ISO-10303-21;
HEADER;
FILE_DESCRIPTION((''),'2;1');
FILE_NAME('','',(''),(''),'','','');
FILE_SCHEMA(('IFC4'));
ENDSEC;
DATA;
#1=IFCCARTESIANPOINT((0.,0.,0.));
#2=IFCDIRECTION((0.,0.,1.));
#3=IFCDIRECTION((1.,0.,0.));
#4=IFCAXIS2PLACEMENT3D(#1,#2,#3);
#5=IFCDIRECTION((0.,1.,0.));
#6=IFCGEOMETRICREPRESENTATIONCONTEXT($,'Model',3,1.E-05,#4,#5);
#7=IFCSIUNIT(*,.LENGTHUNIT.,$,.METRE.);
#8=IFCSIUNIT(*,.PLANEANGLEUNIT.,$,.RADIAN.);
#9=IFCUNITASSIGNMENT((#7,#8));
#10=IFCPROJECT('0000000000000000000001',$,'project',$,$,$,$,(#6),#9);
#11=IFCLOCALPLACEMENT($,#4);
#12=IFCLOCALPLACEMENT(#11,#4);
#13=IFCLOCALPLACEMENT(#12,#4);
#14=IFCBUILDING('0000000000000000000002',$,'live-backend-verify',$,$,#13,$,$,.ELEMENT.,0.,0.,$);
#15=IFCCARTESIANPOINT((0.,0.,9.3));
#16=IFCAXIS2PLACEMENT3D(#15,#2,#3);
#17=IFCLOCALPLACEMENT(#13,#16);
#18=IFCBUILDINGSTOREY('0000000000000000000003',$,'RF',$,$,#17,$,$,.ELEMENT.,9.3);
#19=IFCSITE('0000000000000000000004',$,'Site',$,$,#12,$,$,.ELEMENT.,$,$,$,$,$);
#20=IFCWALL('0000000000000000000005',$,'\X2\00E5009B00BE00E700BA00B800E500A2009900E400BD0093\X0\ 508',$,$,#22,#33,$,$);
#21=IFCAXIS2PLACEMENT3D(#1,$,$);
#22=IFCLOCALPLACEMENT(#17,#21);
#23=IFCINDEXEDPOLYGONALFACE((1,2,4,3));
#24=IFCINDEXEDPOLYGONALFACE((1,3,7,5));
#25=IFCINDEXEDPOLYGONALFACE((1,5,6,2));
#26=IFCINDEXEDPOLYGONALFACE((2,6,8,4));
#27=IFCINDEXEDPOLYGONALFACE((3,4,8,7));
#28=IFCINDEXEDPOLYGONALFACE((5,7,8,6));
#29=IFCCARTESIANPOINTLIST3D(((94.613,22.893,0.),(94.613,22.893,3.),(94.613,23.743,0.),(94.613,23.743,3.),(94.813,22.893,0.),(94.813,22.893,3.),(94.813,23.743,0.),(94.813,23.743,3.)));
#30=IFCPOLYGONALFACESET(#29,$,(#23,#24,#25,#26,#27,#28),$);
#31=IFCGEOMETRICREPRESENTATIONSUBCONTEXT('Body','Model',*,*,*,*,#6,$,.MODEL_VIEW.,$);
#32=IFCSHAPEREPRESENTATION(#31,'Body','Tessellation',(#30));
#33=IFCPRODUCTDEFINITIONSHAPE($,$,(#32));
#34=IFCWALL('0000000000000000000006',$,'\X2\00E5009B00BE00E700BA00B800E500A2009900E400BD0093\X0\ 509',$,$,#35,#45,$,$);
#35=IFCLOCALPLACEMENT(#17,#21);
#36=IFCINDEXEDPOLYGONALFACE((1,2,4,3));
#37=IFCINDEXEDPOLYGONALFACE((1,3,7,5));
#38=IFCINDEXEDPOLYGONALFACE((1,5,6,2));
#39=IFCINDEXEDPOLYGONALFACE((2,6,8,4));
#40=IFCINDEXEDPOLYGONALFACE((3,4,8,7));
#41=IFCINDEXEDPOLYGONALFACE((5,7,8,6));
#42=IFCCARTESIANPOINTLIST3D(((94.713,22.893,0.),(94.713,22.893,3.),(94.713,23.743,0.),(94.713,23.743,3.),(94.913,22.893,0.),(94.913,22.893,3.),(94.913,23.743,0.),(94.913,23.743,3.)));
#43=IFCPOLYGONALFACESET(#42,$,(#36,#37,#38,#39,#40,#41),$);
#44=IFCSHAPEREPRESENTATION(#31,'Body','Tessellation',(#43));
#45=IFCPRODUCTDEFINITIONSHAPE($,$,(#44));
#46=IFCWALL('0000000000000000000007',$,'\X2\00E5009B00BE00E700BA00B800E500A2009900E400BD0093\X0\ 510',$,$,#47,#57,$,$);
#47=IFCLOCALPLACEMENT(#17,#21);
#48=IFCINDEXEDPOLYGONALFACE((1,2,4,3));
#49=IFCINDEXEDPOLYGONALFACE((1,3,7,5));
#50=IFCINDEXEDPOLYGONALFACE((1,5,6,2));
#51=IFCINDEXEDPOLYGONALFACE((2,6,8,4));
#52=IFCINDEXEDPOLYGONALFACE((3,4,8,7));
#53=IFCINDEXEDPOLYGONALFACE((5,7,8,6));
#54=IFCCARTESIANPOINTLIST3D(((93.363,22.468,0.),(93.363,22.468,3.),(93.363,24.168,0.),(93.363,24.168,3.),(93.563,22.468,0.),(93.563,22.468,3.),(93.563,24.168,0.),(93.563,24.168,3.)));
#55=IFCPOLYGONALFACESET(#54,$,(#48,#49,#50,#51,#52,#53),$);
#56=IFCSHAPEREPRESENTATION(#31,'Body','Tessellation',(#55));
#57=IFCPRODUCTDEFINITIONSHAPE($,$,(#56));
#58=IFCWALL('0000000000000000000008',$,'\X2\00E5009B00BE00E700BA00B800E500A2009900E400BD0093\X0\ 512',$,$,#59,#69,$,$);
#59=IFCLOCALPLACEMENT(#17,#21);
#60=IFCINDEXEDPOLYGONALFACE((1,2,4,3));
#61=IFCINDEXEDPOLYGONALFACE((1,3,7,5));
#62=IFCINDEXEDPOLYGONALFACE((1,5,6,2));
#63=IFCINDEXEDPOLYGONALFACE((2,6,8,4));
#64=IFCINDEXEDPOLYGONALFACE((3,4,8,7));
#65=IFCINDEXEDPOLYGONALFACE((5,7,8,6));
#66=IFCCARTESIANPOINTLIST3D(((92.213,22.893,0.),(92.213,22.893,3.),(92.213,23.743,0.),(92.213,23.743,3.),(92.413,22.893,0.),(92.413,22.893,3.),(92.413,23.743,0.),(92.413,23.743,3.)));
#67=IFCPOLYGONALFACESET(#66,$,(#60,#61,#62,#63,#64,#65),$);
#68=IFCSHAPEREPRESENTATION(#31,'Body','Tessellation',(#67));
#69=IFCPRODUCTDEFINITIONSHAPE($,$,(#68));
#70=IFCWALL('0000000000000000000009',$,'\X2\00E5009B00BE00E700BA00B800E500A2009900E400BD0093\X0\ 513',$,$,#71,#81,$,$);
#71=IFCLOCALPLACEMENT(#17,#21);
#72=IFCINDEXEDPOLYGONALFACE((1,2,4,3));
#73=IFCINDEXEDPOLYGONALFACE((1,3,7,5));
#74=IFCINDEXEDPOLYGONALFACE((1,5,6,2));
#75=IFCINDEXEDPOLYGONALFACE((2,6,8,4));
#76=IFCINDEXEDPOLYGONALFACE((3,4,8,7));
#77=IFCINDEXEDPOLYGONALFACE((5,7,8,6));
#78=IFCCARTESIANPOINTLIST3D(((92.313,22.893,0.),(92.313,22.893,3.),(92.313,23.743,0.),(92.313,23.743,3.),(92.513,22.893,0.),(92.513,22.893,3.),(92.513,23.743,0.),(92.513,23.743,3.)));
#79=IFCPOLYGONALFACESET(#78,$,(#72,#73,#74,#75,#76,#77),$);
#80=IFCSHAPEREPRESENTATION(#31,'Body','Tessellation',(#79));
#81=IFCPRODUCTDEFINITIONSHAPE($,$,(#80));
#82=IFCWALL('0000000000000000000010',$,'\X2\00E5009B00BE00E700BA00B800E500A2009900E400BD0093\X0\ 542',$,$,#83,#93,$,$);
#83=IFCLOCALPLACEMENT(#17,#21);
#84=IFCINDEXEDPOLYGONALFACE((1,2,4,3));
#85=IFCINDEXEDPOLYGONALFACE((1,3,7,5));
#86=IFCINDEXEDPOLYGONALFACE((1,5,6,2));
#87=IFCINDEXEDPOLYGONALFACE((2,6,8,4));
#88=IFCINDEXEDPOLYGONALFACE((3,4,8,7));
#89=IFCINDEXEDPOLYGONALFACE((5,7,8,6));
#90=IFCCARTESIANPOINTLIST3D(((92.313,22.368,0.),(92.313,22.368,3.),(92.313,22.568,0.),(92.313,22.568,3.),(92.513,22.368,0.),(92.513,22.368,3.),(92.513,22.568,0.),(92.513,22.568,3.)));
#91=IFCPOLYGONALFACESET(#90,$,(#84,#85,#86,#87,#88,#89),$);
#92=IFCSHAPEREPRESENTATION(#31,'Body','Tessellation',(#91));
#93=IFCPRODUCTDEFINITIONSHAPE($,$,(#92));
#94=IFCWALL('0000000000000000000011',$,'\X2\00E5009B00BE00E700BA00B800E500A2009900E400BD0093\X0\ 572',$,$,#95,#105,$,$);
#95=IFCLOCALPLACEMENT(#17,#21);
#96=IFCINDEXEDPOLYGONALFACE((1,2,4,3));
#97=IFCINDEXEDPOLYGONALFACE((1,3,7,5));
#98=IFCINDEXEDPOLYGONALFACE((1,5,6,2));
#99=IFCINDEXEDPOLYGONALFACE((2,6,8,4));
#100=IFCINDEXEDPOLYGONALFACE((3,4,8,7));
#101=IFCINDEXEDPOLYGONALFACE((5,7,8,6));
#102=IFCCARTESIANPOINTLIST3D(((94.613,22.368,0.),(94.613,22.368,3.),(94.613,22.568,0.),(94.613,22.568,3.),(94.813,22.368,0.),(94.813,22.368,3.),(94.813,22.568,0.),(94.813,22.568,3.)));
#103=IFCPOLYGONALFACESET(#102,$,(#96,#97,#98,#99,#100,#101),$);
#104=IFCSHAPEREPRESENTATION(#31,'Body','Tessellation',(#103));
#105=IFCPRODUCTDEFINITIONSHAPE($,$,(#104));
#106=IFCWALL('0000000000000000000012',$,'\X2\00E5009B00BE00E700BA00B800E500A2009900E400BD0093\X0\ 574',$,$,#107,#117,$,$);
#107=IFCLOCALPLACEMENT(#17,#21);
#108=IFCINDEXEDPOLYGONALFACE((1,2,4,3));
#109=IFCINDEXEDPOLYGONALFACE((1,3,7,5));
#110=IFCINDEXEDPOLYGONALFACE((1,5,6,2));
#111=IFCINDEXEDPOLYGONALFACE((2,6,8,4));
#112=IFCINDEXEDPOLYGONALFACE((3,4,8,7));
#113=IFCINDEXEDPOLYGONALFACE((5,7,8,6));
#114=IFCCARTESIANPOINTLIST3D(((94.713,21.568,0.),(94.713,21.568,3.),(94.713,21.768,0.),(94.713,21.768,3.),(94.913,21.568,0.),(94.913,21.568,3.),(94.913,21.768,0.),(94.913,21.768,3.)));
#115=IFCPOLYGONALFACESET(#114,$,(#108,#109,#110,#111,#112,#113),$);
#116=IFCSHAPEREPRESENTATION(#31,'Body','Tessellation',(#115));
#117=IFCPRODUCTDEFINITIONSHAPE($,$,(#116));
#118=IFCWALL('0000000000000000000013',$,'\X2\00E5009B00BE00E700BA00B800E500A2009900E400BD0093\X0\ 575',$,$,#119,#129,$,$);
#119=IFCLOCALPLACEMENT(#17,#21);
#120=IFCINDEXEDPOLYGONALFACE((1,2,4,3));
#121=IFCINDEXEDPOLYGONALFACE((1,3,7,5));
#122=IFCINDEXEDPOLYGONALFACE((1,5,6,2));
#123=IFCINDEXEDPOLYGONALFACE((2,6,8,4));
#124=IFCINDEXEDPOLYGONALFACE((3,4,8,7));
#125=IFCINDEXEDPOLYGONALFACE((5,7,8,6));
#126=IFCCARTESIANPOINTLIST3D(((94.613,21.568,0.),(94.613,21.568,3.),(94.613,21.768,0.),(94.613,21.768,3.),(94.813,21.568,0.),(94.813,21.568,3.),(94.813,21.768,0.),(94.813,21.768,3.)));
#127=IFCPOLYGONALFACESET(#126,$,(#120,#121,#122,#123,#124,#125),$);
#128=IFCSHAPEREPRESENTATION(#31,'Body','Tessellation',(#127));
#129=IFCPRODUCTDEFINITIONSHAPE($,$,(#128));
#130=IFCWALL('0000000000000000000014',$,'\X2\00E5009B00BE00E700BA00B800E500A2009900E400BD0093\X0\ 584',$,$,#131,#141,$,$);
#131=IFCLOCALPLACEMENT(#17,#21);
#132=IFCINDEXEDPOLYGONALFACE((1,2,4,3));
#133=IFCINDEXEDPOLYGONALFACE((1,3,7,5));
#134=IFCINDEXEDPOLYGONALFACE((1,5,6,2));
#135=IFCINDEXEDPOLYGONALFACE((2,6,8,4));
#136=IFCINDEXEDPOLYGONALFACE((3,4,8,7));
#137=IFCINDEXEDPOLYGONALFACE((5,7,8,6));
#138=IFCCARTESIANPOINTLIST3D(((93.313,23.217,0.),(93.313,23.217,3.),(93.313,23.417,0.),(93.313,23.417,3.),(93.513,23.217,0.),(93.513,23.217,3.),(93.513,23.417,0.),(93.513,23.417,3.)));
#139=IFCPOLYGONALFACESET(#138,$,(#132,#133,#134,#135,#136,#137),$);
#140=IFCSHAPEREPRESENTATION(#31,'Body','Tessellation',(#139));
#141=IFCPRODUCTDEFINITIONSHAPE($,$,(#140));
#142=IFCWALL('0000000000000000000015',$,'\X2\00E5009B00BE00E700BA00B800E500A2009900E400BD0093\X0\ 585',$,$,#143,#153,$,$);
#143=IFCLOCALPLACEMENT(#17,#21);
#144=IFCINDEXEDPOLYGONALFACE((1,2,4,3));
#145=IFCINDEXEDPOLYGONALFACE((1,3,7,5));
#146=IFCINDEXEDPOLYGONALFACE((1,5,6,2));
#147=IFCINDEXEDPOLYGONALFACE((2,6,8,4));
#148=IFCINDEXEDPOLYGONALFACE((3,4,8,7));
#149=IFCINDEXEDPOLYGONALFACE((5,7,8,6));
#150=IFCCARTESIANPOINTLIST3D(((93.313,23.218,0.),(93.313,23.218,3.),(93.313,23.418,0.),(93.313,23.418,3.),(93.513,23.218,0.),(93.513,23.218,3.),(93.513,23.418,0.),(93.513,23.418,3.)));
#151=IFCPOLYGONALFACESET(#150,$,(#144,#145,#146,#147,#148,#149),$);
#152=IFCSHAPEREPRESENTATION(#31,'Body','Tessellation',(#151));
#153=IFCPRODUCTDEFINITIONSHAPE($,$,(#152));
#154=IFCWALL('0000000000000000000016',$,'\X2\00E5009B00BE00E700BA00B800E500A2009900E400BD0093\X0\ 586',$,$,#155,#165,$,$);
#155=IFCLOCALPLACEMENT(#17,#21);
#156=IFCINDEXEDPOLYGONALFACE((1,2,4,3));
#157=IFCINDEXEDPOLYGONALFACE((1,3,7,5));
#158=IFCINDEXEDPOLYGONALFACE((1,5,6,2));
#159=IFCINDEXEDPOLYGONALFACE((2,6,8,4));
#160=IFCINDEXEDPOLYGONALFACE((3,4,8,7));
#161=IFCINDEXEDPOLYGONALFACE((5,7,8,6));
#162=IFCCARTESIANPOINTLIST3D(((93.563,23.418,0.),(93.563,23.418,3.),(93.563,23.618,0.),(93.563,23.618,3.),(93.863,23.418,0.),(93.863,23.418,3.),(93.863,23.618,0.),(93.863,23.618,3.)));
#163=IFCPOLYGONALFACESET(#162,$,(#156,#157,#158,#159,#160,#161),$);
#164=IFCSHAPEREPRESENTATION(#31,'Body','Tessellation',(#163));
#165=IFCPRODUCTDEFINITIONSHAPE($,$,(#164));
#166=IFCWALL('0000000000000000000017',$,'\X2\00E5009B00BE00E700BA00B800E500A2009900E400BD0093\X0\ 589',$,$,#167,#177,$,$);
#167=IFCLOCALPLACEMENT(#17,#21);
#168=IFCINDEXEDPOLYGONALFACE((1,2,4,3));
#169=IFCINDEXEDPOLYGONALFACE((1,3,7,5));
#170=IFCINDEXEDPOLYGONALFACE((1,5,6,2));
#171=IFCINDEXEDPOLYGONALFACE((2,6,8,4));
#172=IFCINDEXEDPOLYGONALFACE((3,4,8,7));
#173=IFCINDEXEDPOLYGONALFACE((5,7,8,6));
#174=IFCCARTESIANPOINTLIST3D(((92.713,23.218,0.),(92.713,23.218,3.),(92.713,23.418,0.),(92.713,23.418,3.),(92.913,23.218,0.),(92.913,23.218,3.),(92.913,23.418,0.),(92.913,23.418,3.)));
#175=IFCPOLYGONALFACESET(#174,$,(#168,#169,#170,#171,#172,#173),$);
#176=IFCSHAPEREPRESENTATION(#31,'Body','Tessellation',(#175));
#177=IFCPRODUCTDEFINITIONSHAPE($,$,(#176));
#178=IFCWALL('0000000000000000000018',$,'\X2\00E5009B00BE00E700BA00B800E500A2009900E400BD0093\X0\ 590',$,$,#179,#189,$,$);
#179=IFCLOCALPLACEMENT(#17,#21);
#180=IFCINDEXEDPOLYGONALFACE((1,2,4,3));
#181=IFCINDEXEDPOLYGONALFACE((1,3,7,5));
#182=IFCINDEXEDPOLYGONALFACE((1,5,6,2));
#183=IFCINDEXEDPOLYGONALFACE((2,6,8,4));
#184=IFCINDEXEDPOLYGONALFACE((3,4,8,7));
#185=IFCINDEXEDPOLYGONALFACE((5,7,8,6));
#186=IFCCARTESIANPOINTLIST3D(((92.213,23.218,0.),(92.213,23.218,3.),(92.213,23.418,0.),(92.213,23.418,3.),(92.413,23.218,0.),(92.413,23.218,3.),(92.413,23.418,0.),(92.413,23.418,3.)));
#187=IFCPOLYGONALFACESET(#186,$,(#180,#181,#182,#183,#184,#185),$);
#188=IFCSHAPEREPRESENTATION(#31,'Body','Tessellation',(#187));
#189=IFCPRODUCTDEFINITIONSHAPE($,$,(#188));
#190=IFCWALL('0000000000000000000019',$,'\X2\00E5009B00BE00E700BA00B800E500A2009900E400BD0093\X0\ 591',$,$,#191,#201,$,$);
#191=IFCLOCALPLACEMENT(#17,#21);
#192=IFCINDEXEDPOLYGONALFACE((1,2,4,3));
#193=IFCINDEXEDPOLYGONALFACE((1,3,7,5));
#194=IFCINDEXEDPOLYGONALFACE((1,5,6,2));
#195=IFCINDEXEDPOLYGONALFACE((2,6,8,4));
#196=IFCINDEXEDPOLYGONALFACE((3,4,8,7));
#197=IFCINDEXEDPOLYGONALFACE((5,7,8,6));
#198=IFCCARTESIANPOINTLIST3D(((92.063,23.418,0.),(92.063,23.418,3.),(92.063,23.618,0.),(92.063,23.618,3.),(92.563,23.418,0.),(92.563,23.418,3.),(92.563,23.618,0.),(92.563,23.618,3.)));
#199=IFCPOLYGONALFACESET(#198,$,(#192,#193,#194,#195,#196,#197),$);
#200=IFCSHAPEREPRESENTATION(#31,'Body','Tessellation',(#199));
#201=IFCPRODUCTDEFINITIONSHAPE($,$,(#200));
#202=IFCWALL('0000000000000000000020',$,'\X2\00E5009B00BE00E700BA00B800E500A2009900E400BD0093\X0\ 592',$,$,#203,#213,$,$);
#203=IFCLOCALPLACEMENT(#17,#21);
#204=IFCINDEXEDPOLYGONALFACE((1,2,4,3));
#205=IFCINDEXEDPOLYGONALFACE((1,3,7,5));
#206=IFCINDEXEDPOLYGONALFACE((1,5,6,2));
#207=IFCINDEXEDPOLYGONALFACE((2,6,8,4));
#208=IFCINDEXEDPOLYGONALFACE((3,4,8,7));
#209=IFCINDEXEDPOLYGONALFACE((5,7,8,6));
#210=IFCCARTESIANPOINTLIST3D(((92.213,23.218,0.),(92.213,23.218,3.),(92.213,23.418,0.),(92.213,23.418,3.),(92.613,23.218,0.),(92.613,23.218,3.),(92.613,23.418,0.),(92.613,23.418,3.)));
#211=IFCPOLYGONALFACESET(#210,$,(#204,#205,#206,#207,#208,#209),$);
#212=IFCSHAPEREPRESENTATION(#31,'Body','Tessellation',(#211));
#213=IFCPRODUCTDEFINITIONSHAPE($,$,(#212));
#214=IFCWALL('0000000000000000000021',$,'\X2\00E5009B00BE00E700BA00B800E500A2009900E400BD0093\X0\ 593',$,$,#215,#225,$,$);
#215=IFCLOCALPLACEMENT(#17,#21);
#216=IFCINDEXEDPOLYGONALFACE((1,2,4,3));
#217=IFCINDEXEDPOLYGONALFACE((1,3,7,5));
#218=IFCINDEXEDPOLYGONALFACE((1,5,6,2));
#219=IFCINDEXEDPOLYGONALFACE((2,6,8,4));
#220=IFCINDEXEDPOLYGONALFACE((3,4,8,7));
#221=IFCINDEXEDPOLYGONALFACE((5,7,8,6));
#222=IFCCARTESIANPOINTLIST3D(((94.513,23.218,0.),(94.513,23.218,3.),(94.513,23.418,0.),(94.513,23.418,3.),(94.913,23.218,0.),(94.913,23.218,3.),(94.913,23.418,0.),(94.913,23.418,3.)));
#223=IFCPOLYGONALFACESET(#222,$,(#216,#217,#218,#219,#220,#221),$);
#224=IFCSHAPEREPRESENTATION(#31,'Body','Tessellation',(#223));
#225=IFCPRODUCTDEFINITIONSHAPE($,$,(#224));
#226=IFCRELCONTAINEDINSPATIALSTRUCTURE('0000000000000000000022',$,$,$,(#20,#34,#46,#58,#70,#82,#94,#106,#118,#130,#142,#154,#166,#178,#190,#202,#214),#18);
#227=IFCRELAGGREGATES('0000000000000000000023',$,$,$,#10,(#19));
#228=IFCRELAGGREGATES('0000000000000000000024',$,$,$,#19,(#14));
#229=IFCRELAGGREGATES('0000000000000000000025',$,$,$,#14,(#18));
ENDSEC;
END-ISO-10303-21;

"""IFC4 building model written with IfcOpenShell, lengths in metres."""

from ifc_helpers import new_model, si_unit, direction, frame, frame_2d, origin_with_axes, place, context, subcontext, project, spatial, rectangle, extrude, element, save


model = new_model("IFC4")

# Units and contexts
model_context = context("Model", 3, precision=1e-05, world=origin_with_axes(), true_north=direction((0.0, 1.0, 0.0)))
body_context = subcontext(model_context, "Body", "Model", "MODEL_VIEW")
ifc_project = project(units=[si_unit("LENGTHUNIT", "METRE"), si_unit("PLANEANGLEUNIT", "RADIAN")], contexts=[model_context])

# Site, building, storey
placement = place(None, origin_with_axes())
site_placement = place(placement, origin_with_axes())
site = spatial("IfcSite", under=ifc_project, at=site_placement, Name="Site", CompositionType="ELEMENT")
building_placement = place(site_placement, origin_with_axes())
building = spatial("IfcBuilding", under=site, at=building_placement, Name="live-backend-verify", CompositionType="ELEMENT", ElevationOfRefHeight=0.0, ElevationOfTerrain=0.0)
storey_placement = place(building_placement, frame((0.0, 0.0, 9.3), z_axis=(0.0, 0.0, 1.0), x_axis=(1.0, 0.0, 0.0)))
storey = spatial("IfcBuildingStorey", under=building, at=storey_placement, Name="RF", CompositionType="ELEMENT", Elevation=9.3)

# Walls
for number, where, z_axis, x_axis, name in (
    (1, (94.713, 23.318, 0.0), (0.0, 0.0, 1.0), (0.0, -1.0, 0.0), "å\u009b¾çº¸å¢\u0099ä½\u0093 508"),
    (2, (94.813, 23.318, 0.0), (0.0, 0.0, 1.0), (0.0, -1.0, 0.0), "å\u009b¾çº¸å¢\u0099ä½\u0093 509"),
):
    element("IfcWall", number, at=place(storey_placement, frame(where, z_axis=z_axis, x_axis=x_axis)), inside=storey, Name=name, context=body_context, shape_type="SweptSolid", body=[
        extrude(rectangle(XDim=0.85, YDim=0.2, at=frame_2d((0.0, 0.0), x_axis=(1.0, 0.0, 0.0))), frame((0.0, 0.0, 0.0), z_axis=(0.0, 0.0, 1.0)), (0.0, 0.0, 1.0), 3.0),
    ])
wall_1_placement = place(storey_placement, frame((93.463, 23.318, 0.0), z_axis=(0.0, 0.0, 1.0), x_axis=(0.0, -1.0, 0.0)))
element("IfcWall", 3, at=wall_1_placement, inside=storey, Name="å\u009b¾çº¸å¢\u0099ä½\u0093 510", context=body_context, shape_type="SweptSolid", body=[
    extrude(rectangle(XDim=1.7, YDim=0.2, at=frame_2d((0.0, 0.0), x_axis=(1.0, 0.0, 0.0))), frame((0.0, 0.0, 0.0), z_axis=(0.0, 0.0, 1.0)), (0.0, 0.0, 1.0), 3.0),
])
for number, where, z_axis, x_axis, name in (
    (4, (92.313, 23.318, 0.0), (0.0, 0.0, 1.0), (0.0, -1.0, 0.0), "å\u009b¾çº¸å¢\u0099ä½\u0093 512"),
    (5, (92.413, 23.318, 0.0), (0.0, 0.0, 1.0), (0.0, -1.0, 0.0), "å\u009b¾çº¸å¢\u0099ä½\u0093 513"),
):
    element("IfcWall", number, at=place(storey_placement, frame(where, z_axis=z_axis, x_axis=x_axis)), inside=storey, Name=name, context=body_context, shape_type="SweptSolid", body=[
        extrude(rectangle(XDim=0.85, YDim=0.2, at=frame_2d((0.0, 0.0), x_axis=(1.0, 0.0, 0.0))), frame((0.0, 0.0, 0.0), z_axis=(0.0, 0.0, 1.0)), (0.0, 0.0, 1.0), 3.0),
    ])
for number, where, z_axis, x_axis, name in (
    (6, (92.413, 22.468, 0.0), (0.0, 0.0, 1.0), (-1.0, 0.0, 0.0), "å\u009b¾çº¸å¢\u0099ä½\u0093 542"),
    (7, (94.713, 22.468, 0.0), (0.0, 0.0, 1.0), (1.0, 0.0, 0.0), "å\u009b¾çº¸å¢\u0099ä½\u0093 572"),
    (8, (94.813, 21.668, 0.0), (0.0, 0.0, 1.0), (0.0, -1.0, 0.0), "å\u009b¾çº¸å¢\u0099ä½\u0093 574"),
    (9, (94.713, 21.668, 0.0), (0.0, 0.0, 1.0), (0.0, -1.0, 0.0), "å\u009b¾çº¸å¢\u0099ä½\u0093 575"),
    (10, (93.413, 23.317, 0.0), (0.0, 0.0, 1.0), (1.0, 0.0, 0.0), "å\u009b¾çº¸å¢\u0099ä½\u0093 584"),
    (11, (93.413, 23.318, 0.0), (0.0, 0.0, 1.0), (1.0, 0.0, 0.0), "å\u009b¾çº¸å¢\u0099ä½\u0093 585"),
):
    element("IfcWall", number, at=place(storey_placement, frame(where, z_axis=z_axis, x_axis=x_axis)), inside=storey, Name=name, context=body_context, shape_type="SweptSolid", body=[
        extrude(rectangle(XDim=0.2, YDim=0.2, at=frame_2d((0.0, 0.0), x_axis=(1.0, 0.0, 0.0))), frame((0.0, 0.0, 0.0), z_axis=(0.0, 0.0, 1.0)), (0.0, 0.0, 1.0), 3.0),
    ])
wall_2_placement = place(storey_placement, frame((93.713, 23.518, 0.0), z_axis=(0.0, 0.0, 1.0), x_axis=(-1.0, 0.0, 0.0)))
element("IfcWall", 12, at=wall_2_placement, inside=storey, Name="å\u009b¾çº¸å¢\u0099ä½\u0093 586", context=body_context, shape_type="SweptSolid", body=[
    extrude(rectangle(XDim=0.3, YDim=0.2, at=frame_2d((0.0, 0.0), x_axis=(1.0, 0.0, 0.0))), frame((0.0, 0.0, 0.0), z_axis=(0.0, 0.0, 1.0)), (0.0, 0.0, 1.0), 3.0),
])
for number, where, z_axis, x_axis, name in (
    (13, (92.813, 23.318, 0.0), (0.0, 0.0, 1.0), (0.0, 1.0, 0.0), "å\u009b¾çº¸å¢\u0099ä½\u0093 589"),
    (14, (92.313, 23.318, 0.0), (0.0, 0.0, 1.0), (0.0, 1.0, 0.0), "å\u009b¾çº¸å¢\u0099ä½\u0093 590"),
):
    element("IfcWall", number, at=place(storey_placement, frame(where, z_axis=z_axis, x_axis=x_axis)), inside=storey, Name=name, context=body_context, shape_type="SweptSolid", body=[
        extrude(rectangle(XDim=0.2, YDim=0.2, at=frame_2d((0.0, 0.0), x_axis=(1.0, 0.0, 0.0))), frame((0.0, 0.0, 0.0), z_axis=(0.0, 0.0, 1.0)), (0.0, 0.0, 1.0), 3.0),
    ])
wall_3_placement = place(storey_placement, frame((92.313, 23.518, 0.0), z_axis=(0.0, 0.0, 1.0), x_axis=(1.0, 0.0, 0.0)))
element("IfcWall", 15, at=wall_3_placement, inside=storey, Name="å\u009b¾çº¸å¢\u0099ä½\u0093 591", context=body_context, shape_type="SweptSolid", body=[
    extrude(rectangle(XDim=0.5, YDim=0.2, at=frame_2d((0.0, 0.0), x_axis=(1.0, 0.0, 0.0))), frame((0.0, 0.0, 0.0), z_axis=(0.0, 0.0, 1.0)), (0.0, 0.0, 1.0), 3.0),
])
for number, where, z_axis, x_axis, name in (
    (16, (92.413, 23.318, 0.0), (0.0, 0.0, 1.0), (1.0, 0.0, 0.0), "å\u009b¾çº¸å¢\u0099ä½\u0093 592"),
    (17, (94.713, 23.318, 0.0), (0.0, 0.0, 1.0), (-1.0, 0.0, 0.0), "å\u009b¾çº¸å¢\u0099ä½\u0093 593"),
):
    element("IfcWall", number, at=place(storey_placement, frame(where, z_axis=z_axis, x_axis=x_axis)), inside=storey, Name=name, context=body_context, shape_type="SweptSolid", body=[
        extrude(rectangle(XDim=0.4, YDim=0.2, at=frame_2d((0.0, 0.0), x_axis=(1.0, 0.0, 0.0))), frame((0.0, 0.0, 0.0), z_axis=(0.0, 0.0, 1.0)), (0.0, 0.0, 1.0), 3.0),
    ])

save(model, "model.ifc")
